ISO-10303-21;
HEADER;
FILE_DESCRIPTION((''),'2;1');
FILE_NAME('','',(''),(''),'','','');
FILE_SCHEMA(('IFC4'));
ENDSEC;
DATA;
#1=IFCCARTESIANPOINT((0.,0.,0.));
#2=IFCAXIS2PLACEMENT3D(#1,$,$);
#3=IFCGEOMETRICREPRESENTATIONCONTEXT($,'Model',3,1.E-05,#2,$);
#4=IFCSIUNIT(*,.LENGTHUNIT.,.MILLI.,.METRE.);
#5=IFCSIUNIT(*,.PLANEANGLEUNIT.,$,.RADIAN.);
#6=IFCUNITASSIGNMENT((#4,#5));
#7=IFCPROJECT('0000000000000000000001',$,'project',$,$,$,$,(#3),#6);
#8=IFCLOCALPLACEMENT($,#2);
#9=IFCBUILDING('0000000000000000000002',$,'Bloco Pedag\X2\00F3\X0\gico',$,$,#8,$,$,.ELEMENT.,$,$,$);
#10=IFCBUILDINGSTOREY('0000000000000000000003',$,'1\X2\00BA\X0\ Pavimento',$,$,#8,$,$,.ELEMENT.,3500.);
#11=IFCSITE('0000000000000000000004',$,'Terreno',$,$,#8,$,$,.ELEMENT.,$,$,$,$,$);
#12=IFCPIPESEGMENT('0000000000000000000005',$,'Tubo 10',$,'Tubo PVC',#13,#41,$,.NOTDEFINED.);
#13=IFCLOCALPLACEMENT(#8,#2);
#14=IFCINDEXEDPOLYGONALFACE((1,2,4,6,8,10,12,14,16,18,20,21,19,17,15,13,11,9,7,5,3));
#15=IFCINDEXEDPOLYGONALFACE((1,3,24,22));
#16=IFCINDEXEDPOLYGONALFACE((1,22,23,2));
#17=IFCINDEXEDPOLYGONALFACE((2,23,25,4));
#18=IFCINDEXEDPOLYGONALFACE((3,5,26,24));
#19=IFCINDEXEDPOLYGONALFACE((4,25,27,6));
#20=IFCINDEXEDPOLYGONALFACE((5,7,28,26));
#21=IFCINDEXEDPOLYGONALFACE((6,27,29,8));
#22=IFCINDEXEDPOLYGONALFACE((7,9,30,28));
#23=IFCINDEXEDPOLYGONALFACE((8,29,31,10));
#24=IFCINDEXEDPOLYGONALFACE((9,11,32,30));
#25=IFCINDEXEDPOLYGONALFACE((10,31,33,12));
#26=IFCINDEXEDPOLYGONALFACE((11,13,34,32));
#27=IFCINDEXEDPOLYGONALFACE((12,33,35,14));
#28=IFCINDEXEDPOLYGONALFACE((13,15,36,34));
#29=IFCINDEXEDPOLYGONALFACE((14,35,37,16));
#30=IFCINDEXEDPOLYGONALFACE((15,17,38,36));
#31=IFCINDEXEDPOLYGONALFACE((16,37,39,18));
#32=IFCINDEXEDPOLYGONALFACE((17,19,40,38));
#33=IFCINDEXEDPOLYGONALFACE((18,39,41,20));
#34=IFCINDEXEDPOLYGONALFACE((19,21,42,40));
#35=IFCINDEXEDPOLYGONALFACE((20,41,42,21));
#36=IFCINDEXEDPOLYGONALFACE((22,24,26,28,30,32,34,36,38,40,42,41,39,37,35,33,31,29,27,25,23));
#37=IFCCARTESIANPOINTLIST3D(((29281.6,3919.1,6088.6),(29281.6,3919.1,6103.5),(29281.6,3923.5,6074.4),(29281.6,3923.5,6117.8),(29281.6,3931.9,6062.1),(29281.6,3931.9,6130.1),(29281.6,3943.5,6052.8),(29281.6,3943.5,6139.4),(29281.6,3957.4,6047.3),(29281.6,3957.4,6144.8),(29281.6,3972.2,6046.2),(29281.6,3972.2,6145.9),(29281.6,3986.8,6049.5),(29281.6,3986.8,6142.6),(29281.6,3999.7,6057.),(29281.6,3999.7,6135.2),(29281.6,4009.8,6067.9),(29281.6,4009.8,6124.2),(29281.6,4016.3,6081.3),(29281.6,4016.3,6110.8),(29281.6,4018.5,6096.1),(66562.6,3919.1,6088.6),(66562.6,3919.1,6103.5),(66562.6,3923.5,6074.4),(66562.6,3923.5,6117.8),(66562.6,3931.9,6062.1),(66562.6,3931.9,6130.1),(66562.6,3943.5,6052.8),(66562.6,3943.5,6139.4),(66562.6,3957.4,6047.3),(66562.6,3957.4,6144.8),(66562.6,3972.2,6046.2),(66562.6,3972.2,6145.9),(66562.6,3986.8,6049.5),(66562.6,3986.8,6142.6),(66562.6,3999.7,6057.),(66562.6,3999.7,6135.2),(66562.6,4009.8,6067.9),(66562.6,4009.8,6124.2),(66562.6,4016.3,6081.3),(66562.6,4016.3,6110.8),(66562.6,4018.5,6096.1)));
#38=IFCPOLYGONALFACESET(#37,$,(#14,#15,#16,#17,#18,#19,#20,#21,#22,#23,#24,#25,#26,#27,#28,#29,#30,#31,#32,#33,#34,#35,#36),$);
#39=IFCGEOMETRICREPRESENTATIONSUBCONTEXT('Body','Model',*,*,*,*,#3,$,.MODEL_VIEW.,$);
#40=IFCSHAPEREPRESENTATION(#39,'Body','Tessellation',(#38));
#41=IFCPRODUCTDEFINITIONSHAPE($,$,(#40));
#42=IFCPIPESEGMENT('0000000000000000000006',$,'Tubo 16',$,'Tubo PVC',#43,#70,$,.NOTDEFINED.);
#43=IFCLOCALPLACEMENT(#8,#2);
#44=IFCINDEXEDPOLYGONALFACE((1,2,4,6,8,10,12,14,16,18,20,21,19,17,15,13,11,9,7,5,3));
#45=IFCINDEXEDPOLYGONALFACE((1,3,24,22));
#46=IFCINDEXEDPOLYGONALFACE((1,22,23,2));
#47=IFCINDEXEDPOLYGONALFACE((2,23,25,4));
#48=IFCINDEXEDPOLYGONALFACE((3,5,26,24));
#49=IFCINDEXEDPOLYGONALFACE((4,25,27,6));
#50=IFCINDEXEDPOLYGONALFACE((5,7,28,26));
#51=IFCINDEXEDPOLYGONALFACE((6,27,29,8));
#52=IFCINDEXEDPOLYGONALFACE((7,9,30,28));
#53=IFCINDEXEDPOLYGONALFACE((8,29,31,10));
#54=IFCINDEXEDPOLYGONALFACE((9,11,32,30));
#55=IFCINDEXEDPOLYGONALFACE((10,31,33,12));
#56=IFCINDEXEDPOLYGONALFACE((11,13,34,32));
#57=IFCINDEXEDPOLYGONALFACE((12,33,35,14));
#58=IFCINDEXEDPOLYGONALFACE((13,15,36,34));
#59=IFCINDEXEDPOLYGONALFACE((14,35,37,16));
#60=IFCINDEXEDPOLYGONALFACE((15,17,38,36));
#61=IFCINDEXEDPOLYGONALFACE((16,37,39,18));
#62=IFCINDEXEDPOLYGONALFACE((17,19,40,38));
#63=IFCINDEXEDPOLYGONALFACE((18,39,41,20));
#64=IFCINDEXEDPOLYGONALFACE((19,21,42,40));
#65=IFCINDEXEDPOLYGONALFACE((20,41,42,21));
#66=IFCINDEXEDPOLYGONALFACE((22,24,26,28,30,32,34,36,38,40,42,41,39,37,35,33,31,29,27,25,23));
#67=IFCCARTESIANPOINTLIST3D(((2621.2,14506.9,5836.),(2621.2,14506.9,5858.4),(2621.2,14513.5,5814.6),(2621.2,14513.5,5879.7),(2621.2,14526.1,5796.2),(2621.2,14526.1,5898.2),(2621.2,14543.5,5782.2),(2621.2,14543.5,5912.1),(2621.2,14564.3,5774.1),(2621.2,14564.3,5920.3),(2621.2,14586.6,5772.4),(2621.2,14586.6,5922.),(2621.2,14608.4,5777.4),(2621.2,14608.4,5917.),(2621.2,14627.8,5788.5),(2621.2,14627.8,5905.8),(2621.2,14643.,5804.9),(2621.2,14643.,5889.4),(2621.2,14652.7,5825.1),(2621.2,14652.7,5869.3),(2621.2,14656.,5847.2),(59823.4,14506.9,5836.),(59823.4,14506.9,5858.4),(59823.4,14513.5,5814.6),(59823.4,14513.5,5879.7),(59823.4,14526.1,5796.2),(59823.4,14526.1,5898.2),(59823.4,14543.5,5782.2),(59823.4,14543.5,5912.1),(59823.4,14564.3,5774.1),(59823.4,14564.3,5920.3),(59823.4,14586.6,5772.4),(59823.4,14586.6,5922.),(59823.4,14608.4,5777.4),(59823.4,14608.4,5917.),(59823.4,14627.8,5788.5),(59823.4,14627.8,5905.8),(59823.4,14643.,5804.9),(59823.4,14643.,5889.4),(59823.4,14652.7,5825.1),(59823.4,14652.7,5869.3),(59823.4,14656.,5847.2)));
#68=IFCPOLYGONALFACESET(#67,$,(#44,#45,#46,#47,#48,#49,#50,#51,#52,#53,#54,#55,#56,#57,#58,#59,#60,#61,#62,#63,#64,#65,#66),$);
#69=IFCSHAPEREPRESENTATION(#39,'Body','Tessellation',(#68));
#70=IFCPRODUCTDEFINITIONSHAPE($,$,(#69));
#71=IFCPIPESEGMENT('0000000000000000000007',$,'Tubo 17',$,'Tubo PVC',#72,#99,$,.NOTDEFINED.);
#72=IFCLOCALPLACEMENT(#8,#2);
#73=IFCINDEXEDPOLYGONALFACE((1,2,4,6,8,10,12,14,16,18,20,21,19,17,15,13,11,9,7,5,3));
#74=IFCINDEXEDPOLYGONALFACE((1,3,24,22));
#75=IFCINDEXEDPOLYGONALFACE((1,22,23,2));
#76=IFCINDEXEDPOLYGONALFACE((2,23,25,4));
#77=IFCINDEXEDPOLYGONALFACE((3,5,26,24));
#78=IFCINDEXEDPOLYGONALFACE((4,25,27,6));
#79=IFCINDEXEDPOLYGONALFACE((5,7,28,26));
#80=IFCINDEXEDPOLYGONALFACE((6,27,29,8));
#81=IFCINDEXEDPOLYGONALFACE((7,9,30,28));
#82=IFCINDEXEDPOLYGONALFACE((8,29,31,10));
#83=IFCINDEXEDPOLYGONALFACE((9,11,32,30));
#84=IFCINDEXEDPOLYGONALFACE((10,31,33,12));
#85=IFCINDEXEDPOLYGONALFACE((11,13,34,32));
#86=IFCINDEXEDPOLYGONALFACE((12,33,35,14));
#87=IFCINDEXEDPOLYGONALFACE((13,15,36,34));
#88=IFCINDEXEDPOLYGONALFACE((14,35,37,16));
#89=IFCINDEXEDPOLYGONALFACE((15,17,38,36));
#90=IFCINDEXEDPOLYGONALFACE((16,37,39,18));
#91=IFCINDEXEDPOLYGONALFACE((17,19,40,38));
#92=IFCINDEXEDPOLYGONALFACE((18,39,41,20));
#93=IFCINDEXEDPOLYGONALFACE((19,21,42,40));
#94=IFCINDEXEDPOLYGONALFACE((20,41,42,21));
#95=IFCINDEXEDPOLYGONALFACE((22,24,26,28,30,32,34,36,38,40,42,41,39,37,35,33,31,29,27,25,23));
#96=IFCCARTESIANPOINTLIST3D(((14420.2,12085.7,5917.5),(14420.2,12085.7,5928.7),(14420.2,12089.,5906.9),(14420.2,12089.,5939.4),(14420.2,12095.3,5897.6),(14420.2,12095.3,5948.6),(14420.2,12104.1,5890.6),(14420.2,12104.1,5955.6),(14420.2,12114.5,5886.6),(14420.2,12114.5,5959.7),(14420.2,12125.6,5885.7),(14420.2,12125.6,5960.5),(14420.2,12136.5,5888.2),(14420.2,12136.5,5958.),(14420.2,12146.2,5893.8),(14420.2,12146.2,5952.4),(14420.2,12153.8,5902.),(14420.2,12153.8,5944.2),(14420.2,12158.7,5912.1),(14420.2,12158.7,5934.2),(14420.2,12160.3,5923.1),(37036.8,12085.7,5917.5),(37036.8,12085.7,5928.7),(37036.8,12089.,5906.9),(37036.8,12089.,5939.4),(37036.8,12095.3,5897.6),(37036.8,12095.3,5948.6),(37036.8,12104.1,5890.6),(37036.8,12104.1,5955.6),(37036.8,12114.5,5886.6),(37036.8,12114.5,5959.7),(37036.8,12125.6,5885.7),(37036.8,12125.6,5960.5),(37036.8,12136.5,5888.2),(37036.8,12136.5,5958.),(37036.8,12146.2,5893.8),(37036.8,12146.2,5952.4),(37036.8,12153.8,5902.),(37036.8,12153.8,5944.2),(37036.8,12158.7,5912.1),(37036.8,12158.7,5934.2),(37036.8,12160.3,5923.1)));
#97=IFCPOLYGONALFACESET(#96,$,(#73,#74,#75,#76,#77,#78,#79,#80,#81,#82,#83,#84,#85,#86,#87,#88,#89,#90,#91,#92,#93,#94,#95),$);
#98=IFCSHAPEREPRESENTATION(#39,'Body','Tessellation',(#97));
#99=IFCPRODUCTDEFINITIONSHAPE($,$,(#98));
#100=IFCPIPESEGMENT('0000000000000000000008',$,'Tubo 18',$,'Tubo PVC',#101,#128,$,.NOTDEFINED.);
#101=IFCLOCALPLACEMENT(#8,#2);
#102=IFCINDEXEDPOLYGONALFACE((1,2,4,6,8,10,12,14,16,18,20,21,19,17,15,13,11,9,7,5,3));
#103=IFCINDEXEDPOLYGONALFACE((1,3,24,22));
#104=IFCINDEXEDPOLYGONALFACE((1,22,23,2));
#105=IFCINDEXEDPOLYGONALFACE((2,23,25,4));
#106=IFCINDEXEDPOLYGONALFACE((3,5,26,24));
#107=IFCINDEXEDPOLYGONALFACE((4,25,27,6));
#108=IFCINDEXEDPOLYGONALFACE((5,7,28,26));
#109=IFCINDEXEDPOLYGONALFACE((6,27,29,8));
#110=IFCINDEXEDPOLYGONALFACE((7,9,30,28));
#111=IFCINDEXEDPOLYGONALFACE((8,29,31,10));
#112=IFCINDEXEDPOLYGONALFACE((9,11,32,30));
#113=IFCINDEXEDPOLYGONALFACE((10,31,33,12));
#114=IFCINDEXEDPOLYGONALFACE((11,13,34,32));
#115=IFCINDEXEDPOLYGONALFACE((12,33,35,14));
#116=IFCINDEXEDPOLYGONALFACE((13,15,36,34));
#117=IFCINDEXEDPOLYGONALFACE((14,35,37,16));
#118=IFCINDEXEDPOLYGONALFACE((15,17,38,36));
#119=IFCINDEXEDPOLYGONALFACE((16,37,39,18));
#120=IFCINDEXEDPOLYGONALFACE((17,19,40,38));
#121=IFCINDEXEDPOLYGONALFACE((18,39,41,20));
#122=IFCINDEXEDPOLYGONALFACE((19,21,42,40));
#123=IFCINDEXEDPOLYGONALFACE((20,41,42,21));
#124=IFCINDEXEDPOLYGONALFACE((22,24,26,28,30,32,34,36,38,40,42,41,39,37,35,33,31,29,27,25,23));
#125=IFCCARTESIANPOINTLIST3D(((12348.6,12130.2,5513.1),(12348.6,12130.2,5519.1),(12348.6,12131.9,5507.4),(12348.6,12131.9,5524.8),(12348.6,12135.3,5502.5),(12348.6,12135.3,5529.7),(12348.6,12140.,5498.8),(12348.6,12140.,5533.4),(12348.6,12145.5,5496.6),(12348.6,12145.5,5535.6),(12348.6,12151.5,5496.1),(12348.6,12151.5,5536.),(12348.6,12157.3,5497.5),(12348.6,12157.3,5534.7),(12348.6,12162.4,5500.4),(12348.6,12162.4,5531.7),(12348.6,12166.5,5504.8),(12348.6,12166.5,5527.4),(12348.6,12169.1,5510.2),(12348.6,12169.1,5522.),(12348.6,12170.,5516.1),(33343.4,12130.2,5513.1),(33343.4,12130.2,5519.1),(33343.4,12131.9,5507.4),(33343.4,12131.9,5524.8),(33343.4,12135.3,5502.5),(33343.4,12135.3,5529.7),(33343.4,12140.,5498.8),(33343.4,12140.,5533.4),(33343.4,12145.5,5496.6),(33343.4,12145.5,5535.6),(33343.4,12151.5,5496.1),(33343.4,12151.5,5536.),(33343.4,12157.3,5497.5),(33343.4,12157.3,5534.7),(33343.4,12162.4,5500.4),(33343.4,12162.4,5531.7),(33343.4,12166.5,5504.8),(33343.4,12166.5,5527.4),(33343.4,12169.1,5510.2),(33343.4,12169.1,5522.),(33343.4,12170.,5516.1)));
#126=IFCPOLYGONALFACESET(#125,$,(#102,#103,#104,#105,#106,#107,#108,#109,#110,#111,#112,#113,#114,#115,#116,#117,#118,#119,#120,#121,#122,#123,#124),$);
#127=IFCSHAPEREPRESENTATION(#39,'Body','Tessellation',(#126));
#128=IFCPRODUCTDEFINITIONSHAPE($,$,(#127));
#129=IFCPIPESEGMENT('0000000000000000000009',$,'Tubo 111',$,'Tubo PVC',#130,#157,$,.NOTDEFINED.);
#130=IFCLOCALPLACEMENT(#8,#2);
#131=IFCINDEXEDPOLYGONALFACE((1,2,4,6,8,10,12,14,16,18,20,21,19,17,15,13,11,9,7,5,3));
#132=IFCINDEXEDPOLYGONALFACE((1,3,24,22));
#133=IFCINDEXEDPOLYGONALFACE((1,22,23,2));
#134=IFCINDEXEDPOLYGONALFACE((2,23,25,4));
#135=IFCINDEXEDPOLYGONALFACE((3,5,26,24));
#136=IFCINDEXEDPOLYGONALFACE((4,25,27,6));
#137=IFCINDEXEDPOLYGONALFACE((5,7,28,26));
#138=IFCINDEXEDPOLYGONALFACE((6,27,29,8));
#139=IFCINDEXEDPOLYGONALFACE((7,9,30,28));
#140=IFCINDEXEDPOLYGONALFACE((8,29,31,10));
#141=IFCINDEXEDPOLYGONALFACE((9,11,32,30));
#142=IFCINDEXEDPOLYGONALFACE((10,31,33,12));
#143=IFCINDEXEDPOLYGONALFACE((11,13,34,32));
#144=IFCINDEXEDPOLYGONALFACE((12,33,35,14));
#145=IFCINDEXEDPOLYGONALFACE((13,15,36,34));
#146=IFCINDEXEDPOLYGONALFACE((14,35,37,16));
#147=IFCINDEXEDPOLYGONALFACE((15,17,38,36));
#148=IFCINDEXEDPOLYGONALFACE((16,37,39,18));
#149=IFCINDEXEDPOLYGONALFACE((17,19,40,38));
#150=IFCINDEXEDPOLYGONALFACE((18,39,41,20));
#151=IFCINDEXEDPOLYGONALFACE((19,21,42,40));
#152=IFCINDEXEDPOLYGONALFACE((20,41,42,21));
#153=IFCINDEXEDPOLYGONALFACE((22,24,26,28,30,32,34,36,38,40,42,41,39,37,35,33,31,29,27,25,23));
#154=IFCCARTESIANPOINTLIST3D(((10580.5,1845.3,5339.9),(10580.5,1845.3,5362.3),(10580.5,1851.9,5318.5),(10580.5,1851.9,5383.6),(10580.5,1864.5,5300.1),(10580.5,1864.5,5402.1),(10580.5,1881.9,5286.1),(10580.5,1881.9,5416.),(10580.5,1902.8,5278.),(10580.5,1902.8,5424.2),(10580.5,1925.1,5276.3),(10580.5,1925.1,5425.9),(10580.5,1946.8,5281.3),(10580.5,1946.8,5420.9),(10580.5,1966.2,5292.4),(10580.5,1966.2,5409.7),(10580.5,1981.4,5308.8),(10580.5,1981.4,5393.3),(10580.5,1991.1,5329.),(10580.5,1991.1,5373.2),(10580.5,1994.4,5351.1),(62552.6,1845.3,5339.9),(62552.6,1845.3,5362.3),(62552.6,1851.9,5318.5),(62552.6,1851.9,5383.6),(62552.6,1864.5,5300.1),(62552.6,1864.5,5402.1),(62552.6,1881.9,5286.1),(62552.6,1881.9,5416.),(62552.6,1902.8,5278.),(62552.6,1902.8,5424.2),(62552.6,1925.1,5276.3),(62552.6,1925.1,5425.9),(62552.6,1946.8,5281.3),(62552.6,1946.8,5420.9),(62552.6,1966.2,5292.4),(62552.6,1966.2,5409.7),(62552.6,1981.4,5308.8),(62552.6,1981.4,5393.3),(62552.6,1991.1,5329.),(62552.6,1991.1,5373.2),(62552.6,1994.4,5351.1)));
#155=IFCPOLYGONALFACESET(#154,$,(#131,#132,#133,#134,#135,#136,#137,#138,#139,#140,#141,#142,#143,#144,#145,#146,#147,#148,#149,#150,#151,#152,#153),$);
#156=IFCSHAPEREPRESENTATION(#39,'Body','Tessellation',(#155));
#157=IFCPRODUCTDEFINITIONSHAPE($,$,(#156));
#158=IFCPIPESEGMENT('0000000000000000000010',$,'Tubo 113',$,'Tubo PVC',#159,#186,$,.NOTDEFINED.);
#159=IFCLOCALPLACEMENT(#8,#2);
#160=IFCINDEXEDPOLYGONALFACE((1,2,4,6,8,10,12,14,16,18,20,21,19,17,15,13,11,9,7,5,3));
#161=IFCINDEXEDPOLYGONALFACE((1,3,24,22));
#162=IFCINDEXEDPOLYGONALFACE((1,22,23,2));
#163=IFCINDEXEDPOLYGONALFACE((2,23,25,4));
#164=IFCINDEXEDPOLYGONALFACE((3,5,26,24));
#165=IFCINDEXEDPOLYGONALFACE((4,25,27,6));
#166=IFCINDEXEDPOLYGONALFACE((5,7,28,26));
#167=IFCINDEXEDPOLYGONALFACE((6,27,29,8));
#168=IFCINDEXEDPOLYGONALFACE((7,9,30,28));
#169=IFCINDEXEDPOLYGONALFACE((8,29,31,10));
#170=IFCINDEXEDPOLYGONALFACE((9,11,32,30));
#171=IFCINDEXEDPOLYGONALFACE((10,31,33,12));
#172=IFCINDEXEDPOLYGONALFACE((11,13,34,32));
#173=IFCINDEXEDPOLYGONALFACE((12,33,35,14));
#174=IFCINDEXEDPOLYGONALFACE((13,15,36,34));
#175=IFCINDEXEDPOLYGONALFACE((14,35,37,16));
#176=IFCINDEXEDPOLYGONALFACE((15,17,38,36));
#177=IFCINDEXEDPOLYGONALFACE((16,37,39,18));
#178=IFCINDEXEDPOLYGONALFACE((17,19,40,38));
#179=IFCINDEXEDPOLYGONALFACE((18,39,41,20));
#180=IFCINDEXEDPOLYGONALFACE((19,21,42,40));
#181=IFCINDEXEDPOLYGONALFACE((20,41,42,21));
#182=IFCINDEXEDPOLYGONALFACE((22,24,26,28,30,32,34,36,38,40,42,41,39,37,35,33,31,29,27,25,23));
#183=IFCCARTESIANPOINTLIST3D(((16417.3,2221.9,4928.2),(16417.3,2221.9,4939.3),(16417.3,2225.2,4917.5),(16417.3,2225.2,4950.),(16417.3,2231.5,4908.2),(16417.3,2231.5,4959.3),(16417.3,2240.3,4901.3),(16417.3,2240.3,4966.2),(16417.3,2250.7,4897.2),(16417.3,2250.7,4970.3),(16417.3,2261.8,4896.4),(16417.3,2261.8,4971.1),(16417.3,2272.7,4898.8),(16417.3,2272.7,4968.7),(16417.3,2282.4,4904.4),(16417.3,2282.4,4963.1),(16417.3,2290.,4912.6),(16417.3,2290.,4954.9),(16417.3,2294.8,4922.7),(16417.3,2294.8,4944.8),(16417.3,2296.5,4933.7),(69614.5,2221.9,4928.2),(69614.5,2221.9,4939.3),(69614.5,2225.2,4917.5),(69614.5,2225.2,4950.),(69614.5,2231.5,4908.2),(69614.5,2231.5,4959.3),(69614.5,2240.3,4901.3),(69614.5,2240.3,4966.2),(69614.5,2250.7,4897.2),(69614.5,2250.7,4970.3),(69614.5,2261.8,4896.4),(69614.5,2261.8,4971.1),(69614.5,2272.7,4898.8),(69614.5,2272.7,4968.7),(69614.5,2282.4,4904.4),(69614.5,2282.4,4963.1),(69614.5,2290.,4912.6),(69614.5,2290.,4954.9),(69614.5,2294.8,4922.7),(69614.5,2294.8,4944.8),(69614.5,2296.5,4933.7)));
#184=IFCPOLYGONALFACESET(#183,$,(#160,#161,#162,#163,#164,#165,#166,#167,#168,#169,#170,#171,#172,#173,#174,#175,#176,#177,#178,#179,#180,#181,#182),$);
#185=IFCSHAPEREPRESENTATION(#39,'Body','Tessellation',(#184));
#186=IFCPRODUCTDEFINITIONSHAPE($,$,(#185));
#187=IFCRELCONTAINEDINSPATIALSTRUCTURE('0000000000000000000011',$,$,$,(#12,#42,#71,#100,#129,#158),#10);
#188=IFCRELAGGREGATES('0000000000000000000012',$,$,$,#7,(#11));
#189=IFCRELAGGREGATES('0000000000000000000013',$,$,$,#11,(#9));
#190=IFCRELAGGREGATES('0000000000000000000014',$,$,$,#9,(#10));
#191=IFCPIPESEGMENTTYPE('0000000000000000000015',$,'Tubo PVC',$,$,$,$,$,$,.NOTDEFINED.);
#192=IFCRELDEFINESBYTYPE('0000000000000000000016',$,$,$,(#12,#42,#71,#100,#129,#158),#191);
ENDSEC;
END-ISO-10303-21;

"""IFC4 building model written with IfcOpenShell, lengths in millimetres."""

from ifc_helpers import new_model, si_unit, frame, origin, origin_2d, place, context, subcontext, project, spatial, circle, extrude, type_object, element, save


model = new_model("IFC4")

# Units and contexts
model_context = context("Model", 3, precision=1e-05, world=origin())
body_context = subcontext(model_context, "Body", "Model", "MODEL_VIEW")
ifc_project = project(units=[si_unit("LENGTHUNIT", "METRE", prefix="MILLI"), si_unit("PLANEANGLEUNIT", "RADIAN")], contexts=[model_context])

# Site, building, storey
placement = place(None, origin())
site = spatial("IfcSite", under=ifc_project, at=placement, Name="Terreno", CompositionType="ELEMENT")
building = spatial("IfcBuilding", under=site, at=placement, Name="Bloco Pedagógico", CompositionType="ELEMENT")
storey = spatial("IfcBuildingStorey", under=building, at=placement, Name="1º Pavimento", CompositionType="ELEMENT", Elevation=3500.0)

# Pipe segments
pipe_segment_type = type_object("IfcPipeSegmentType", Name="Tubo PVC", PredefinedType="NOTDEFINED")
pipe_segment_1_placement = place(None, frame((29281.6, 3968.5, 6096.1), z_axis=(1.0, 0.0, 0.0), x_axis=(0.0, 1.0, 0.0)))
element("IfcPipeSegment", 1, at=pipe_segment_1_placement, inside=storey, type_object=pipe_segment_type, Name="Tubo 10", ObjectType="Tubo PVC", PredefinedType="NOTDEFINED", context=body_context, shape_type="SweptSolid", body=[
    extrude(circle(Radius=50.0, at=origin_2d()), None, (0.0, 0.0, 1.0), 37281.0),
])
pipe_segment_2_placement = place(None, frame((2621.2, 14581.0, 5847.2), z_axis=(1.0, 0.0, 0.0), x_axis=(0.0, 1.0, 0.0)))
element("IfcPipeSegment", 2, at=pipe_segment_2_placement, inside=storey, type_object=pipe_segment_type, Name="Tubo 16", ObjectType="Tubo PVC", PredefinedType="NOTDEFINED", context=body_context, shape_type="SweptSolid", body=[
    extrude(circle(Radius=75.0, at=origin_2d()), None, (0.0, 0.0, 1.0), 57202.2),
])
pipe_segment_3_placement = place(None, frame((14420.2, 12122.8, 5923.1), z_axis=(1.0, 0.0, 0.0), x_axis=(0.0, 1.0, 0.0)))
element("IfcPipeSegment", 3, at=pipe_segment_3_placement, inside=storey, type_object=pipe_segment_type, Name="Tubo 17", ObjectType="Tubo PVC", PredefinedType="NOTDEFINED", context=body_context, shape_type="SweptSolid", body=[
    extrude(circle(Radius=37.5, at=origin_2d()), None, (0.0, 0.0, 1.0), 22616.6),
])
pipe_segment_4_placement = place(None, frame((12348.6, 12150.0, 5516.1), z_axis=(1.0, 0.0, 0.0), x_axis=(0.0, 1.0, 0.0)))
element("IfcPipeSegment", 4, at=pipe_segment_4_placement, inside=storey, type_object=pipe_segment_type, Name="Tubo 18", ObjectType="Tubo PVC", PredefinedType="NOTDEFINED", context=body_context, shape_type="SweptSolid", body=[
    extrude(circle(Radius=20.0, at=origin_2d()), None, (0.0, 0.0, 1.0), 20994.8),
])
pipe_segment_5_placement = place(None, frame((10580.5, 1919.4, 5351.1), z_axis=(1.0, 0.0, 0.0), x_axis=(0.0, 1.0, 0.0)))
element("IfcPipeSegment", 5, at=pipe_segment_5_placement, inside=storey, type_object=pipe_segment_type, Name="Tubo 111", ObjectType="Tubo PVC", PredefinedType="NOTDEFINED", context=body_context, shape_type="SweptSolid", body=[
    extrude(circle(Radius=75.0, at=origin_2d()), None, (0.0, 0.0, 1.0), 51972.1),
])
pipe_segment_6_placement = place(None, frame((16417.3, 2259.0, 4933.7), z_axis=(1.0, 0.0, 0.0), x_axis=(0.0, 1.0, 0.0)))
element("IfcPipeSegment", 6, at=pipe_segment_6_placement, inside=storey, type_object=pipe_segment_type, Name="Tubo 113", ObjectType="Tubo PVC", PredefinedType="NOTDEFINED", context=body_context, shape_type="SweptSolid", body=[
    extrude(circle(Radius=37.5, at=origin_2d()), None, (0.0, 0.0, 1.0), 53197.2),
])

save(model, "model.ifc")
